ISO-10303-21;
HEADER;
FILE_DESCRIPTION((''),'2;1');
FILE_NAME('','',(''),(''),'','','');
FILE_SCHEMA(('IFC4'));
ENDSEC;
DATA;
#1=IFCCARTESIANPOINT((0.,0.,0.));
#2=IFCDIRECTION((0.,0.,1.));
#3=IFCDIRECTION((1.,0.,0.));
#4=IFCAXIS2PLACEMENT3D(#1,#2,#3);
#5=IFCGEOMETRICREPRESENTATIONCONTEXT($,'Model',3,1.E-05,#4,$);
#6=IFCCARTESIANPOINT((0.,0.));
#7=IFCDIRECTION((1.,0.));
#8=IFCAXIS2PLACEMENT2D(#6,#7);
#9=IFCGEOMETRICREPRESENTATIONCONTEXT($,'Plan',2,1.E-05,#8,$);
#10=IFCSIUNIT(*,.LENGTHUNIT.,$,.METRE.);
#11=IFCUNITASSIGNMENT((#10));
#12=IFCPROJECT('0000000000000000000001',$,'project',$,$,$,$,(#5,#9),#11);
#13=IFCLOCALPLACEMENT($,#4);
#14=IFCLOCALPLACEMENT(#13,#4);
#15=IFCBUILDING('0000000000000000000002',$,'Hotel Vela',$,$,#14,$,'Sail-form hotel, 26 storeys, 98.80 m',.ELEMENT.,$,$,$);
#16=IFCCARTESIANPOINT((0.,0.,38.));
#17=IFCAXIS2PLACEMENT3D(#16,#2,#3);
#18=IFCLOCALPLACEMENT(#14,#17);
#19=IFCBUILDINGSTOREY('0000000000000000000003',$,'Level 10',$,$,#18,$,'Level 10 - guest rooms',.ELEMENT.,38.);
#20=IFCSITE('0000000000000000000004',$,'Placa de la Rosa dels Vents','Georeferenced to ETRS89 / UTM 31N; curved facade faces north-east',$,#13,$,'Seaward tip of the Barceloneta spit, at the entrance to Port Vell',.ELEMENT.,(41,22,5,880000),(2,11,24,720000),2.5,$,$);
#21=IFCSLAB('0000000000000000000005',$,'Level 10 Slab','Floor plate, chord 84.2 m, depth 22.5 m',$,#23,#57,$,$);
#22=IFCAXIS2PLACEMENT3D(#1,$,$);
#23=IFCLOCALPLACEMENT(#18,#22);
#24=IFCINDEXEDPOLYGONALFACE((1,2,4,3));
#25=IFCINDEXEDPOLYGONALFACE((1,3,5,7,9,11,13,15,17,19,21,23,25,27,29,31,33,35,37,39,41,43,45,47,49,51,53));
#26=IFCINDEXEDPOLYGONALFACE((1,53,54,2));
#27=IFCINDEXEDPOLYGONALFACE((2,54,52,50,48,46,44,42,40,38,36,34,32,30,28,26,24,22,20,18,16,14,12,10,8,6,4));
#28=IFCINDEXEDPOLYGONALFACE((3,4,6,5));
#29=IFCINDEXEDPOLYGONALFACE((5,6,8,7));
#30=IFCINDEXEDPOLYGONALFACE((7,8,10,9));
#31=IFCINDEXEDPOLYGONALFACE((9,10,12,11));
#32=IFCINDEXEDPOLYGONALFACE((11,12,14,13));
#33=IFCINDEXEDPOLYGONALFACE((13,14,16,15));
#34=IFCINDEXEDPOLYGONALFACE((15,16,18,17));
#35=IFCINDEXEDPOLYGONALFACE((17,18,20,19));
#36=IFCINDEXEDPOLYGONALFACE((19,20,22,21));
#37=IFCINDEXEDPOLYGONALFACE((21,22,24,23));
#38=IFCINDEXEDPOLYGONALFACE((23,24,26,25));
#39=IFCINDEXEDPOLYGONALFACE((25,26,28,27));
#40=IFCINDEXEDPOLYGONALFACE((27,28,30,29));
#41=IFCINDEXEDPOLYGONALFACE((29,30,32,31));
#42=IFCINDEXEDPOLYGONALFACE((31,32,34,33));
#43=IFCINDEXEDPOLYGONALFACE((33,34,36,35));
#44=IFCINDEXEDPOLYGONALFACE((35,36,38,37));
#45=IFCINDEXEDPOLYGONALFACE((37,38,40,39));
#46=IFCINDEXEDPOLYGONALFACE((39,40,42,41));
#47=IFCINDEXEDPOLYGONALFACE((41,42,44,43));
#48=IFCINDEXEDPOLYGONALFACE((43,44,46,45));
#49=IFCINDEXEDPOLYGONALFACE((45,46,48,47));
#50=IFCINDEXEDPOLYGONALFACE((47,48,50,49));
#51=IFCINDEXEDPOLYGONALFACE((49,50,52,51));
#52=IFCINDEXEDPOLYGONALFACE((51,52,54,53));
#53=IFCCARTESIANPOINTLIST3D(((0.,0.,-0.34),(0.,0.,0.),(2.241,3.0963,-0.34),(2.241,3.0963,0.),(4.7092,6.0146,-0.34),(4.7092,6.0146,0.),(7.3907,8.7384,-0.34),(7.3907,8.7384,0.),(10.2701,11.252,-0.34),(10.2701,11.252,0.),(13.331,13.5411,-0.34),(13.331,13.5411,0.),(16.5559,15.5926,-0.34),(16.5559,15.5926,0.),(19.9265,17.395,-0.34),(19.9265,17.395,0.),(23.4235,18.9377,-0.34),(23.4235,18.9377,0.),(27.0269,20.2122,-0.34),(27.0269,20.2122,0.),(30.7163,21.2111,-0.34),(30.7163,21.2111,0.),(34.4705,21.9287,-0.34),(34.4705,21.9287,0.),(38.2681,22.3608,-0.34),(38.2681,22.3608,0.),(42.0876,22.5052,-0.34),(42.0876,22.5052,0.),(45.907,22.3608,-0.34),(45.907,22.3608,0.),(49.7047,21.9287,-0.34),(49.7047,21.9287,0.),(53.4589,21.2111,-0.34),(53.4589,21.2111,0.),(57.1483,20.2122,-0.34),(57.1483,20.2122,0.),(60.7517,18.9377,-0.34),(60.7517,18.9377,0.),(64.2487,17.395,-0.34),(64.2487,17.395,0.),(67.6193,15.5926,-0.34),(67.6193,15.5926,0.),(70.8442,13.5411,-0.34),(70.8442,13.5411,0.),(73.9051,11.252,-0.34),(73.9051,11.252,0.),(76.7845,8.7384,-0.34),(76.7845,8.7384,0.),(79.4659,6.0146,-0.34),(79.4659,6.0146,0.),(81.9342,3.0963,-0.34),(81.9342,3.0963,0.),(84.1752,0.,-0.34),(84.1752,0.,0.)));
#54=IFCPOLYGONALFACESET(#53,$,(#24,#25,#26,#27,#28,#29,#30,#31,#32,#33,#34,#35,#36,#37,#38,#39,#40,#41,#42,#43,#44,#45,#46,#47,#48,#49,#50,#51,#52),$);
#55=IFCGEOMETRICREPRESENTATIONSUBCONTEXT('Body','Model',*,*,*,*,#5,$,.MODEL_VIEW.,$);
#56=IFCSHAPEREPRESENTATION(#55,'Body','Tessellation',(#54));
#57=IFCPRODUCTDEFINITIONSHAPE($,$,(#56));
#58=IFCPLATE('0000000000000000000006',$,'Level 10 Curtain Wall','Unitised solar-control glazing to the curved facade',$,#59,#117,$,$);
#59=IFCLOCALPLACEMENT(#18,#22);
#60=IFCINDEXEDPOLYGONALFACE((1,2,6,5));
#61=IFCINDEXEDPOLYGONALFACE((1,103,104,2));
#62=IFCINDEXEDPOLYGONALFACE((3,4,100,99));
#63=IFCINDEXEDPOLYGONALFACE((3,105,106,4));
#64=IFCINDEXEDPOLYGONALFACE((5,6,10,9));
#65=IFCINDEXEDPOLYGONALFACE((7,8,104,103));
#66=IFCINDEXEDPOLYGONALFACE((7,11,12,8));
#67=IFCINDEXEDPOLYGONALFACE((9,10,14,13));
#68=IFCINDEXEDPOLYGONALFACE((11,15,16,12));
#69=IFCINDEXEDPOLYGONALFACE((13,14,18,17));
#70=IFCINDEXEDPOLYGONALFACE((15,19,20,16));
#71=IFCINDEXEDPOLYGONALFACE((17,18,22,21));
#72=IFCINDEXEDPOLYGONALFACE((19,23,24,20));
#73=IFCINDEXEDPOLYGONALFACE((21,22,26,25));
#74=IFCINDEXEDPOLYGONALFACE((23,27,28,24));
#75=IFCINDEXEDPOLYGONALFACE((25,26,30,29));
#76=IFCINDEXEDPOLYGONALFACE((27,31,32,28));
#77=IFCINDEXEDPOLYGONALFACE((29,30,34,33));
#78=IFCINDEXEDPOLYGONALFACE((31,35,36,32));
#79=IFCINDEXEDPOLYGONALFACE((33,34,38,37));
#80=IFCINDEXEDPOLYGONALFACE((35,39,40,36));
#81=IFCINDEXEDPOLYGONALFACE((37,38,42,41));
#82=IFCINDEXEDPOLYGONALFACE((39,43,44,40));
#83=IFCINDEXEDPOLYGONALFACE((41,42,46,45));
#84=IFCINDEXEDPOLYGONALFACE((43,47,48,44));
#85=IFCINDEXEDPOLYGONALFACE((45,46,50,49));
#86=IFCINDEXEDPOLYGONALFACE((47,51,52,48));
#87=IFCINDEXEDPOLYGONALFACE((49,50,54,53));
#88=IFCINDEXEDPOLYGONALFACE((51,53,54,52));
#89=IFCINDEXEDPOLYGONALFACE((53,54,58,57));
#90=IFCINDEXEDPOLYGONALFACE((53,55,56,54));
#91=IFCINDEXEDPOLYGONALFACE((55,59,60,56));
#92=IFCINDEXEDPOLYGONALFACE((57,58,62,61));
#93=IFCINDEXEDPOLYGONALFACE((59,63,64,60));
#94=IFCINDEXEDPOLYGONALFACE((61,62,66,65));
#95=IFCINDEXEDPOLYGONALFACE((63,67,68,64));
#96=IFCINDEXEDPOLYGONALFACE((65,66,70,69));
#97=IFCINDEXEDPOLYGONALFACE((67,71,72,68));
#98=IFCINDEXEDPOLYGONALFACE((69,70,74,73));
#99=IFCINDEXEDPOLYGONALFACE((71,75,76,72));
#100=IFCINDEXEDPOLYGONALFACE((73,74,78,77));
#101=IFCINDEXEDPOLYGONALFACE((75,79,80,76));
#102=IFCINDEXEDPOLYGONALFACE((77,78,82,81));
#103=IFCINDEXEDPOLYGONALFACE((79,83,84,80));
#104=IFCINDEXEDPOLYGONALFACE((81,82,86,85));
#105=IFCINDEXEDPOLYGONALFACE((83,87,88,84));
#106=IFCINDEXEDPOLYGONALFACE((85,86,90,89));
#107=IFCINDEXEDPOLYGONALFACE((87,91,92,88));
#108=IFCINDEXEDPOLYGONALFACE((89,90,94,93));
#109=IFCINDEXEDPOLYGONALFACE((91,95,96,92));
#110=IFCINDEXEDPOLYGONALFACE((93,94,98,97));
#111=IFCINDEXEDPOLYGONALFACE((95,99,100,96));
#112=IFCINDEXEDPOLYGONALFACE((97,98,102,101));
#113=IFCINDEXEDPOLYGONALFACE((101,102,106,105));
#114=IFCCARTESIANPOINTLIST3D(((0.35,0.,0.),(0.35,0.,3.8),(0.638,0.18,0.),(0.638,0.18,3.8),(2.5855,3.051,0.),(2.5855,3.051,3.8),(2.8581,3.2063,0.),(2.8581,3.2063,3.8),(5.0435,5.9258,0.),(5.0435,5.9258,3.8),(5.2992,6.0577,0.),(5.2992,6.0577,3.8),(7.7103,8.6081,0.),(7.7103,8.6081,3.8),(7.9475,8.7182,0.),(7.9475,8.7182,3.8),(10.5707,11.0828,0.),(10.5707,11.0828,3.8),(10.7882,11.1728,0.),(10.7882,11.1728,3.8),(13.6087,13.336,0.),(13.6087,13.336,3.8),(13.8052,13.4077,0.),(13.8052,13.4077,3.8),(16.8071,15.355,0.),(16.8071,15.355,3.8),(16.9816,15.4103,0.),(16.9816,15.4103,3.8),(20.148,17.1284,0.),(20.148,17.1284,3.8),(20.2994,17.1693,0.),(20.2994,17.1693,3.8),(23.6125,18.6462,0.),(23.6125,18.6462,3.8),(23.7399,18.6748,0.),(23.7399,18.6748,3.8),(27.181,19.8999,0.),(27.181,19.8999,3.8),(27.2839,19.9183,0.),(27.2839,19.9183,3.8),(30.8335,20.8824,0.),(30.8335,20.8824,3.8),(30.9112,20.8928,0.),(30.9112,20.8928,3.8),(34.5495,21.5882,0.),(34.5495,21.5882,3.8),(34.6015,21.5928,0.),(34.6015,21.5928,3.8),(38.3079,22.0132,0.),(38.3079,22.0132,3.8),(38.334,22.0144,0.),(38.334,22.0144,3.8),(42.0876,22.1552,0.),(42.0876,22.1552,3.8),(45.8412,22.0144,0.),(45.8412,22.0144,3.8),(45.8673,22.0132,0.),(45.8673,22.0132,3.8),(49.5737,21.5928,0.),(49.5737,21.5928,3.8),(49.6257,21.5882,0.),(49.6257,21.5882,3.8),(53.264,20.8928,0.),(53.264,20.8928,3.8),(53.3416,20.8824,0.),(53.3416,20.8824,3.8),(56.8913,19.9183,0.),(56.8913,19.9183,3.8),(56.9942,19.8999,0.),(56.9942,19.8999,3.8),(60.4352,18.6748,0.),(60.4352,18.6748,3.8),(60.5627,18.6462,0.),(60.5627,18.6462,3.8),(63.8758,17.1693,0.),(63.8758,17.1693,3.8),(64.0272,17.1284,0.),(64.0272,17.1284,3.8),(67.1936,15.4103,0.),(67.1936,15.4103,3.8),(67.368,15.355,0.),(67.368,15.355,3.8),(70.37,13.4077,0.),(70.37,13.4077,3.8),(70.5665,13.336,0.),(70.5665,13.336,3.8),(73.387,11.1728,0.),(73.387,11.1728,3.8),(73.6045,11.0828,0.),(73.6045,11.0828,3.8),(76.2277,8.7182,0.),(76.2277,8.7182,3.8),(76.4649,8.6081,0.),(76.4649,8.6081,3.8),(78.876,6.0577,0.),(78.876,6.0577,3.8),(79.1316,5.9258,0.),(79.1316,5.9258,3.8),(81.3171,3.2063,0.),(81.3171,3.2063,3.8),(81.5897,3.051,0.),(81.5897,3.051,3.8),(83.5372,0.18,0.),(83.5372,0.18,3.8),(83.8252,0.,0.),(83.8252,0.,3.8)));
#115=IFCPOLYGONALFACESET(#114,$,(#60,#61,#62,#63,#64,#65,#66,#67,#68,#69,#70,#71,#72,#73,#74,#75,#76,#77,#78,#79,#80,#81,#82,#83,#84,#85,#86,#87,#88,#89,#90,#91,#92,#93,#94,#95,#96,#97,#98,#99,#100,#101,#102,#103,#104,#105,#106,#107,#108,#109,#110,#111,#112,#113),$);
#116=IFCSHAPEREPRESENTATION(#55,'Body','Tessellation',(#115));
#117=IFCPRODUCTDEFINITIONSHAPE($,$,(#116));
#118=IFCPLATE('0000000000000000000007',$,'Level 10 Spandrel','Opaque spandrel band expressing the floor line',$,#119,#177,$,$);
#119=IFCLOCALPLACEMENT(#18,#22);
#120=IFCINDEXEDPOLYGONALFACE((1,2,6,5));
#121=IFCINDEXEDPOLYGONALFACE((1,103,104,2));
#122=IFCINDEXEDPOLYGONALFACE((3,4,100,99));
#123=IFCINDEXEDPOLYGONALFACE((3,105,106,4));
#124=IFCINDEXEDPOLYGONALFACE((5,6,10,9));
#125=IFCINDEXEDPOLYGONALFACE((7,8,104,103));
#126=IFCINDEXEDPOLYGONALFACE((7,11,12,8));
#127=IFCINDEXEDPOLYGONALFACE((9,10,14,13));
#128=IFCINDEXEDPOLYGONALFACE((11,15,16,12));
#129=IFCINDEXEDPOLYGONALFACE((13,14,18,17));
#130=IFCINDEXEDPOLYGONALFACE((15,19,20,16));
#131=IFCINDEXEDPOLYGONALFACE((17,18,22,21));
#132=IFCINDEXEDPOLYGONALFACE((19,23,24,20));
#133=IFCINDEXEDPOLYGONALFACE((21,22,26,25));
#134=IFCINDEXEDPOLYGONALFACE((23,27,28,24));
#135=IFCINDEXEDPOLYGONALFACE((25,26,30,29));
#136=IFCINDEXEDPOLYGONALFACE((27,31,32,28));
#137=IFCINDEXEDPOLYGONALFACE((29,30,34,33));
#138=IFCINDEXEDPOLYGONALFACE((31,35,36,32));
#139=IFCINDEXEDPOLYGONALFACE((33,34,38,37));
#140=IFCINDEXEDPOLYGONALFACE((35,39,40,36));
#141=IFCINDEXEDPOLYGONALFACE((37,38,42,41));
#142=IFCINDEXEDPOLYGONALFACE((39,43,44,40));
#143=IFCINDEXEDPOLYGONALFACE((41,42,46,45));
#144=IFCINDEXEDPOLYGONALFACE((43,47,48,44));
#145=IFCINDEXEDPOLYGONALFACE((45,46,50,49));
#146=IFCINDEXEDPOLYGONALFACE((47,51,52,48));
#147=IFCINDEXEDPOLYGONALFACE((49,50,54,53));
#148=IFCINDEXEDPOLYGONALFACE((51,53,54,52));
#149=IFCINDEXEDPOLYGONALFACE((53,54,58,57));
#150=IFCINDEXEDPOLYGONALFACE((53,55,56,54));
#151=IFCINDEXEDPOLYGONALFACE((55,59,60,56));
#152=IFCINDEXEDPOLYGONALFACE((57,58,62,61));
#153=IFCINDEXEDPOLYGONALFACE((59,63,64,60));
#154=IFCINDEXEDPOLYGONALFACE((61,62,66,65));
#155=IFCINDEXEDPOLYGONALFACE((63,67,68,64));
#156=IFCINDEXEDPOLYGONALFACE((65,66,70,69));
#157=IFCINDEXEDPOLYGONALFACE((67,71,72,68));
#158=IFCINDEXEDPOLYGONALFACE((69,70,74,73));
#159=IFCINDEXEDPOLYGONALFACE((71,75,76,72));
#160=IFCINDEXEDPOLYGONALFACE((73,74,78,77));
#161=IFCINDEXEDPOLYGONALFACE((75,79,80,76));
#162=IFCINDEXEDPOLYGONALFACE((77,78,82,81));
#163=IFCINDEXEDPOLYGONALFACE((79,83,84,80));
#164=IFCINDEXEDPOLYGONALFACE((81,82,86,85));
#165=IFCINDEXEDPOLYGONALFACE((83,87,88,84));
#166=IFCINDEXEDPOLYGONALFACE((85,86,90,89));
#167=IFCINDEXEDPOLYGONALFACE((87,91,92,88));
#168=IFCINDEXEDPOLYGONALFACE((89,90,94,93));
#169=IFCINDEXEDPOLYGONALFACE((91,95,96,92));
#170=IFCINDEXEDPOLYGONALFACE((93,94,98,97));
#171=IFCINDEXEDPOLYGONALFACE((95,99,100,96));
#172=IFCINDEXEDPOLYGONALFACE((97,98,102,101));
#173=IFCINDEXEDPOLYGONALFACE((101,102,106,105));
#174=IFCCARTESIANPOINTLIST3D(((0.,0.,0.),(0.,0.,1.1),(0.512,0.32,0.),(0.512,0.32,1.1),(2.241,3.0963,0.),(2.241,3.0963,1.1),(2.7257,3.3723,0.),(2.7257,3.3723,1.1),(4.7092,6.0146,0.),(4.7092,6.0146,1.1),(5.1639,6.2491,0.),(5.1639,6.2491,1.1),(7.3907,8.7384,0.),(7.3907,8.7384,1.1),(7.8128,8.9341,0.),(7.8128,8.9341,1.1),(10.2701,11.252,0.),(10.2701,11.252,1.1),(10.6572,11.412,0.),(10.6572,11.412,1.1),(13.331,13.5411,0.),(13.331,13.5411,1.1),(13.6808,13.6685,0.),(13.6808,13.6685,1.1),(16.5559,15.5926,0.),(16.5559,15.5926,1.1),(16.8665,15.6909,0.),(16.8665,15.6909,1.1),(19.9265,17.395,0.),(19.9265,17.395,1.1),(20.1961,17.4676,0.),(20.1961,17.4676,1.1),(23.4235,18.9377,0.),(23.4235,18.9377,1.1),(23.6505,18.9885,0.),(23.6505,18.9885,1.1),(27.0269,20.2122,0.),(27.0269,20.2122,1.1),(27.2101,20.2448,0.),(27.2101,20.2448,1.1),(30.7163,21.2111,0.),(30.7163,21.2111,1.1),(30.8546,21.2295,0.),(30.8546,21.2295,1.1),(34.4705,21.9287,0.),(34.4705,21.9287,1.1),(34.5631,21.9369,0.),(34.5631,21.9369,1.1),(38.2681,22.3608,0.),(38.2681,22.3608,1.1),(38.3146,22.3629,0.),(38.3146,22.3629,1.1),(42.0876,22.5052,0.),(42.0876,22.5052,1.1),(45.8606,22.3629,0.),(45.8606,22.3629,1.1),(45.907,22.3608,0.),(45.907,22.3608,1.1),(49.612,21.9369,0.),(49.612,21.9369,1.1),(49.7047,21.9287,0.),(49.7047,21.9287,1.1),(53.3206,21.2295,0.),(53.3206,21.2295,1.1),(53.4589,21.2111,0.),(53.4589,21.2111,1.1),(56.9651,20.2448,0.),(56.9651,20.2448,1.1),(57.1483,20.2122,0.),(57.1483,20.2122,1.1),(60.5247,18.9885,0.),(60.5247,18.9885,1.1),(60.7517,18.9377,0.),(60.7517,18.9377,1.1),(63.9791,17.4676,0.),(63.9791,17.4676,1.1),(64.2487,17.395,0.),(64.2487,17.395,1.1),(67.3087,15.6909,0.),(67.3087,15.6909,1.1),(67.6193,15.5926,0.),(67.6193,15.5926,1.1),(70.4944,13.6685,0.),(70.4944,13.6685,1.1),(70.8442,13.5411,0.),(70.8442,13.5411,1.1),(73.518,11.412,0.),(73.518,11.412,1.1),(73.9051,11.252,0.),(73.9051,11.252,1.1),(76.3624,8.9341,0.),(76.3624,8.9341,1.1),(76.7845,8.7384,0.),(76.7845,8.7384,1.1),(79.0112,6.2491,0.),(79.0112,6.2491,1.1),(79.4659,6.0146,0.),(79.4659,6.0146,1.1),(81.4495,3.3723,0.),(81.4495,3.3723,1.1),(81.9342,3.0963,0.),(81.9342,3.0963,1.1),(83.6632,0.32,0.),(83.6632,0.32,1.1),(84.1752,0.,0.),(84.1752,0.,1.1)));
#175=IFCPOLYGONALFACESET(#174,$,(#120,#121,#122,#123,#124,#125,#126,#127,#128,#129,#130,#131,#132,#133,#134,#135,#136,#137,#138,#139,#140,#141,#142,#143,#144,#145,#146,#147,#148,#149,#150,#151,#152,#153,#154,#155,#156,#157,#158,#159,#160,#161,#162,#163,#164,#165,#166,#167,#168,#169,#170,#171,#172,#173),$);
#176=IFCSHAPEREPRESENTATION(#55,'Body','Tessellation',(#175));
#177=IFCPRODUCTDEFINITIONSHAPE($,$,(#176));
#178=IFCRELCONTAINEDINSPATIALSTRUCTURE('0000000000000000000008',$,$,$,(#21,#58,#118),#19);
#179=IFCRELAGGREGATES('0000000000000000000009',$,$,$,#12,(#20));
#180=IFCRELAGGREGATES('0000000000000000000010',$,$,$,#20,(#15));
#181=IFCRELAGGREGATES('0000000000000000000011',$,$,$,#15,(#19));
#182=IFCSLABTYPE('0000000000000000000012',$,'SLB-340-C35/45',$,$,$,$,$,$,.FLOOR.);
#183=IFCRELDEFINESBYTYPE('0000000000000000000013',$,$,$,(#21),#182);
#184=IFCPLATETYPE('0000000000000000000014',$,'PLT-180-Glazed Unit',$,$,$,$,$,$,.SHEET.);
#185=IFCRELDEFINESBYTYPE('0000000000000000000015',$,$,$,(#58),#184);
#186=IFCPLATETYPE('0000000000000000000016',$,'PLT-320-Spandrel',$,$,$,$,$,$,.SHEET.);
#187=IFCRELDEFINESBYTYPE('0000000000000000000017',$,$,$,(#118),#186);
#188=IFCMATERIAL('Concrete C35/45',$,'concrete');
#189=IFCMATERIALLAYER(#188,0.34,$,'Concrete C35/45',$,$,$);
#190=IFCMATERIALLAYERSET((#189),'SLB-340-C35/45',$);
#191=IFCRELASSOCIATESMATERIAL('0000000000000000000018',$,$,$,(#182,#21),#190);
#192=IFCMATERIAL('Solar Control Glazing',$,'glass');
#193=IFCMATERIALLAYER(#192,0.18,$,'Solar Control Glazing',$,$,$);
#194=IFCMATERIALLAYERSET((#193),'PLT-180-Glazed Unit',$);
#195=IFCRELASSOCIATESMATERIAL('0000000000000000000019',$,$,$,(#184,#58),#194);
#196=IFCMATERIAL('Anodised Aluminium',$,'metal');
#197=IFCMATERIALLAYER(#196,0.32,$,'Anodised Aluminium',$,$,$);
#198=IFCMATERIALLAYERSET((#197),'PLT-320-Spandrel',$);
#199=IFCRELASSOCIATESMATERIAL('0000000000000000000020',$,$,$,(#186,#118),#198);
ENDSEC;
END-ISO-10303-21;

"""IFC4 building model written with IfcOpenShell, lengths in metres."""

from ifc_helpers import new_model, si_unit, frame, origin_with_axes, origin_2d_with_axis, place, context, subcontext, project, spatial, line, indexed_curve, outline, extrude, material, layer, layer_set, layer_usage, type_object, element, save


model = new_model("IFC4")

# Units and contexts
model_context = context("Model", 3, precision=1e-05, world=origin_with_axes())
plan_context = context("Plan", 2, precision=1e-05, world=origin_2d_with_axis())
body_context = subcontext(model_context, "Body", "Model", "MODEL_VIEW")
ifc_project = project(units=[si_unit("LENGTHUNIT", "METRE")], contexts=[model_context, plan_context])

# Site, building, storey
site_placement = place(None, origin_with_axes())
site = spatial("IfcSite", under=ifc_project, at=site_placement, Name="Placa de la Rosa dels Vents", Description="Georeferenced to ETRS89 / UTM 31N; curved facade faces north-east", LongName="Seaward tip of the Barceloneta spit, at the entrance to Port Vell", CompositionType="ELEMENT", RefLatitude=(41, 22, 5, 880000), RefLongitude=(2, 11, 24, 720000), RefElevation=2.5)
building_placement = place(site_placement, origin_with_axes())
building = spatial("IfcBuilding", under=site, at=building_placement, Name="Hotel Vela", LongName="Sail-form hotel, 26 storeys, 98.80 m", CompositionType="ELEMENT")
storey_placement = place(building_placement, frame((0.0, 0.0, 38.0), z_axis=(0.0, 0.0, 1.0), x_axis=(1.0, 0.0, 0.0)))
storey = spatial("IfcBuildingStorey", under=building, at=storey_placement, Name="Level 10", LongName="Level 10 - guest rooms", CompositionType="ELEMENT", Elevation=38.0)

# Slab
ifc_material_1 = material(Name="Concrete C35/45", Category="concrete")
ifc_layer_1 = layer(ifc_material_1, 0.34, Name="Concrete C35/45")
ifc_layer_set_1 = layer_set([ifc_layer_1], Name="SLB-340-C35/45")
ifc_layer_usage_1 = layer_usage(ifc_layer_set_1, "AXIS3", "POSITIVE", 0.0)
slab_type = type_object("IfcSlabType", Name="SLB-340-C35/45", PredefinedType="FLOOR", material=ifc_layer_set_1)
slab_placement = place(storey_placement, frame((0.0, 0.0, -0.34), z_axis=(0.0, 0.0, 1.0), x_axis=(1.0, 0.0, 0.0)))
element("IfcSlab", 1, at=slab_placement, inside=storey, type_object=slab_type, material=ifc_layer_usage_1, Name="Level 10 Slab", Description="Floor plate, chord 84.2 m, depth 22.5 m", context=body_context, shape_type="SweptSolid", body=[
    extrude(outline(indexed_curve([(0.0, 0.0), (84.1752, 0.0), (81.9342, 3.0963), (79.4659, 6.0146), (76.7845, 8.7384), (73.9051, 11.252), (70.8442, 13.5411), (67.6193, 15.5926), (64.2487, 17.395), (60.7517, 18.9377), (57.1483, 20.2122), (53.4589, 21.2111), (49.7047, 21.9287), (45.907, 22.3608), (42.0876, 22.5052), (38.2681, 22.3608), (34.4705, 21.9287), (30.7163, 21.2111), (27.0269, 20.2122), (23.4235, 18.9377), (19.9265, 17.395), (16.5559, 15.5926), (13.331, 13.5411), (10.2701, 11.252), (7.3907, 8.7384), (4.7092, 6.0146), (2.241, 3.0963)], segments=[line(1, 2, 3, 4, 5, 6, 7, 8, 9, 10, 11, 12, 13, 14, 15, 16, 17, 18, 19, 20, 21, 22, 23, 24, 25, 26, 27, 1)])), origin_with_axes(), (0.0, 0.0, 1.0), 0.34),
])

# Plates
ifc_material_2 = material(Name="Solar Control Glazing", Category="glass")
ifc_layer_2 = layer(ifc_material_2, 0.18, Name="Solar Control Glazing")
ifc_layer_set_2 = layer_set([ifc_layer_2], Name="PLT-180-Glazed Unit")
ifc_layer_usage_2 = layer_usage(ifc_layer_set_2, "AXIS2", "POSITIVE", 0.0)
plate_type_1 = type_object("IfcPlateType", Name="PLT-180-Glazed Unit", PredefinedType="SHEET", material=ifc_layer_set_2)
plate_1_placement = place(storey_placement, frame((0.35, 0.0, 0.0), z_axis=(0.0, 0.0, 1.0), x_axis=(1.0, 0.0, 0.0)))
element("IfcPlate", 2, at=plate_1_placement, inside=storey, type_object=plate_type_1, material=ifc_layer_usage_2, Name="Level 10 Curtain Wall", Description="Unitised solar-control glazing to the curved facade", context=body_context, shape_type="SweptSolid", body=[
    extrude(outline(indexed_curve([(83.4752, 0.0), (81.2397, 3.051), (78.7816, 5.9258), (76.1149, 8.6081), (73.2545, 11.0828), (70.2165, 13.336), (67.018, 15.355), (63.6772, 17.1284), (60.2127, 18.6462), (56.6442, 19.8999), (52.9916, 20.8824), (49.2757, 21.5882), (45.5173, 22.0132), (41.7376, 22.1552), (37.9579, 22.0132), (34.1995, 21.5882), (30.4835, 20.8824), (26.831, 19.8999), (23.2625, 18.6462), (19.798, 17.1284), (16.4571, 15.355), (13.2587, 13.336), (10.2207, 11.0828), (7.3603, 8.6081), (4.6935, 5.9258), (2.2355, 3.051), (0.0, 0.0), (83.1872, 0.18), (2.5081, 3.2063), (4.9492, 6.0577), (7.5975, 8.7182), (10.4382, 11.1728), (13.4552, 13.4077), (16.6316, 15.4103), (19.9494, 17.1693), (23.3899, 18.6748), (26.9339, 19.9183), (30.5612, 20.8928), (34.2515, 21.5928), (37.984, 22.0144), (41.7376, 22.1552), (45.4912, 22.0144), (49.2237, 21.5928), (52.914, 20.8928), (56.5413, 19.9183), (60.0852, 18.6748), (63.5258, 17.1693), (66.8436, 15.4103), (70.02, 13.4077), (73.037, 11.1728), (75.8777, 8.7182), (78.526, 6.0577), (80.9671, 3.2063), (0.288, 0.18)], segments=[line(1, 2, 3, 4, 5, 6, 7, 8, 9, 10, 11, 12, 13, 14, 15, 16, 17, 18, 19, 20, 21, 22, 23, 24, 25, 26, 27, 28, 29, 30, 31, 32, 33, 34, 35, 36, 37, 38, 39, 40, 41, 42, 43, 44, 45, 46, 47, 48, 49, 50, 51, 52, 53, 54, 1)])), origin_with_axes(), (0.0, 0.0, 1.0), 3.8),
])
ifc_material_3 = material(Name="Anodised Aluminium", Category="metal")
ifc_layer_3 = layer(ifc_material_3, 0.32, Name="Anodised Aluminium")
ifc_layer_set_3 = layer_set([ifc_layer_3], Name="PLT-320-Spandrel")
ifc_layer_usage_3 = layer_usage(ifc_layer_set_3, "AXIS2", "POSITIVE", 0.0)
plate_type_2 = type_object("IfcPlateType", Name="PLT-320-Spandrel", PredefinedType="SHEET", material=ifc_layer_set_3)
plate_2_placement = place(storey_placement, origin_with_axes())
element("IfcPlate", 3, at=plate_2_placement, inside=storey, type_object=plate_type_2, material=ifc_layer_usage_3, Name="Level 10 Spandrel", Description="Opaque spandrel band expressing the floor line", context=body_context, shape_type="SweptSolid", body=[
    extrude(outline(indexed_curve([(84.1752, 0.0), (81.9342, 3.0963), (79.4659, 6.0146), (76.7845, 8.7384), (73.9051, 11.252), (70.8442, 13.5411), (67.6193, 15.5926), (64.2487, 17.395), (60.7517, 18.9377), (57.1483, 20.2122), (53.4589, 21.2111), (49.7047, 21.9287), (45.907, 22.3608), (42.0876, 22.5052), (38.2681, 22.3608), (34.4705, 21.9287), (30.7163, 21.2111), (27.0269, 20.2122), (23.4235, 18.9377), (19.9265, 17.395), (16.5559, 15.5926), (13.331, 13.5411), (10.2701, 11.252), (7.3907, 8.7384), (4.7092, 6.0146), (2.241, 3.0963), (0.0, 0.0), (83.6632, 0.32), (2.7257, 3.3723), (5.1639, 6.2491), (7.8128, 8.9341), (10.6572, 11.412), (13.6808, 13.6685), (16.8665, 15.6909), (20.1961, 17.4676), (23.6505, 18.9885), (27.2101, 20.2448), (30.8546, 21.2295), (34.5631, 21.9369), (38.3146, 22.3629), (42.0876, 22.5052), (45.8606, 22.3629), (49.612, 21.9369), (53.3206, 21.2295), (56.9651, 20.2448), (60.5247, 18.9885), (63.9791, 17.4676), (67.3087, 15.6909), (70.4944, 13.6685), (73.518, 11.412), (76.3624, 8.9341), (79.0112, 6.2491), (81.4495, 3.3723), (0.512, 0.32)], segments=[line(1, 2, 3, 4, 5, 6, 7, 8, 9, 10, 11, 12, 13, 14, 15, 16, 17, 18, 19, 20, 21, 22, 23, 24, 25, 26, 27, 28, 29, 30, 31, 32, 33, 34, 35, 36, 37, 38, 39, 40, 41, 42, 43, 44, 45, 46, 47, 48, 49, 50, 51, 52, 53, 54, 1)])), origin_with_axes(), (0.0, 0.0, 1.0), 1.1),
])

save(model, "model.ifc")
